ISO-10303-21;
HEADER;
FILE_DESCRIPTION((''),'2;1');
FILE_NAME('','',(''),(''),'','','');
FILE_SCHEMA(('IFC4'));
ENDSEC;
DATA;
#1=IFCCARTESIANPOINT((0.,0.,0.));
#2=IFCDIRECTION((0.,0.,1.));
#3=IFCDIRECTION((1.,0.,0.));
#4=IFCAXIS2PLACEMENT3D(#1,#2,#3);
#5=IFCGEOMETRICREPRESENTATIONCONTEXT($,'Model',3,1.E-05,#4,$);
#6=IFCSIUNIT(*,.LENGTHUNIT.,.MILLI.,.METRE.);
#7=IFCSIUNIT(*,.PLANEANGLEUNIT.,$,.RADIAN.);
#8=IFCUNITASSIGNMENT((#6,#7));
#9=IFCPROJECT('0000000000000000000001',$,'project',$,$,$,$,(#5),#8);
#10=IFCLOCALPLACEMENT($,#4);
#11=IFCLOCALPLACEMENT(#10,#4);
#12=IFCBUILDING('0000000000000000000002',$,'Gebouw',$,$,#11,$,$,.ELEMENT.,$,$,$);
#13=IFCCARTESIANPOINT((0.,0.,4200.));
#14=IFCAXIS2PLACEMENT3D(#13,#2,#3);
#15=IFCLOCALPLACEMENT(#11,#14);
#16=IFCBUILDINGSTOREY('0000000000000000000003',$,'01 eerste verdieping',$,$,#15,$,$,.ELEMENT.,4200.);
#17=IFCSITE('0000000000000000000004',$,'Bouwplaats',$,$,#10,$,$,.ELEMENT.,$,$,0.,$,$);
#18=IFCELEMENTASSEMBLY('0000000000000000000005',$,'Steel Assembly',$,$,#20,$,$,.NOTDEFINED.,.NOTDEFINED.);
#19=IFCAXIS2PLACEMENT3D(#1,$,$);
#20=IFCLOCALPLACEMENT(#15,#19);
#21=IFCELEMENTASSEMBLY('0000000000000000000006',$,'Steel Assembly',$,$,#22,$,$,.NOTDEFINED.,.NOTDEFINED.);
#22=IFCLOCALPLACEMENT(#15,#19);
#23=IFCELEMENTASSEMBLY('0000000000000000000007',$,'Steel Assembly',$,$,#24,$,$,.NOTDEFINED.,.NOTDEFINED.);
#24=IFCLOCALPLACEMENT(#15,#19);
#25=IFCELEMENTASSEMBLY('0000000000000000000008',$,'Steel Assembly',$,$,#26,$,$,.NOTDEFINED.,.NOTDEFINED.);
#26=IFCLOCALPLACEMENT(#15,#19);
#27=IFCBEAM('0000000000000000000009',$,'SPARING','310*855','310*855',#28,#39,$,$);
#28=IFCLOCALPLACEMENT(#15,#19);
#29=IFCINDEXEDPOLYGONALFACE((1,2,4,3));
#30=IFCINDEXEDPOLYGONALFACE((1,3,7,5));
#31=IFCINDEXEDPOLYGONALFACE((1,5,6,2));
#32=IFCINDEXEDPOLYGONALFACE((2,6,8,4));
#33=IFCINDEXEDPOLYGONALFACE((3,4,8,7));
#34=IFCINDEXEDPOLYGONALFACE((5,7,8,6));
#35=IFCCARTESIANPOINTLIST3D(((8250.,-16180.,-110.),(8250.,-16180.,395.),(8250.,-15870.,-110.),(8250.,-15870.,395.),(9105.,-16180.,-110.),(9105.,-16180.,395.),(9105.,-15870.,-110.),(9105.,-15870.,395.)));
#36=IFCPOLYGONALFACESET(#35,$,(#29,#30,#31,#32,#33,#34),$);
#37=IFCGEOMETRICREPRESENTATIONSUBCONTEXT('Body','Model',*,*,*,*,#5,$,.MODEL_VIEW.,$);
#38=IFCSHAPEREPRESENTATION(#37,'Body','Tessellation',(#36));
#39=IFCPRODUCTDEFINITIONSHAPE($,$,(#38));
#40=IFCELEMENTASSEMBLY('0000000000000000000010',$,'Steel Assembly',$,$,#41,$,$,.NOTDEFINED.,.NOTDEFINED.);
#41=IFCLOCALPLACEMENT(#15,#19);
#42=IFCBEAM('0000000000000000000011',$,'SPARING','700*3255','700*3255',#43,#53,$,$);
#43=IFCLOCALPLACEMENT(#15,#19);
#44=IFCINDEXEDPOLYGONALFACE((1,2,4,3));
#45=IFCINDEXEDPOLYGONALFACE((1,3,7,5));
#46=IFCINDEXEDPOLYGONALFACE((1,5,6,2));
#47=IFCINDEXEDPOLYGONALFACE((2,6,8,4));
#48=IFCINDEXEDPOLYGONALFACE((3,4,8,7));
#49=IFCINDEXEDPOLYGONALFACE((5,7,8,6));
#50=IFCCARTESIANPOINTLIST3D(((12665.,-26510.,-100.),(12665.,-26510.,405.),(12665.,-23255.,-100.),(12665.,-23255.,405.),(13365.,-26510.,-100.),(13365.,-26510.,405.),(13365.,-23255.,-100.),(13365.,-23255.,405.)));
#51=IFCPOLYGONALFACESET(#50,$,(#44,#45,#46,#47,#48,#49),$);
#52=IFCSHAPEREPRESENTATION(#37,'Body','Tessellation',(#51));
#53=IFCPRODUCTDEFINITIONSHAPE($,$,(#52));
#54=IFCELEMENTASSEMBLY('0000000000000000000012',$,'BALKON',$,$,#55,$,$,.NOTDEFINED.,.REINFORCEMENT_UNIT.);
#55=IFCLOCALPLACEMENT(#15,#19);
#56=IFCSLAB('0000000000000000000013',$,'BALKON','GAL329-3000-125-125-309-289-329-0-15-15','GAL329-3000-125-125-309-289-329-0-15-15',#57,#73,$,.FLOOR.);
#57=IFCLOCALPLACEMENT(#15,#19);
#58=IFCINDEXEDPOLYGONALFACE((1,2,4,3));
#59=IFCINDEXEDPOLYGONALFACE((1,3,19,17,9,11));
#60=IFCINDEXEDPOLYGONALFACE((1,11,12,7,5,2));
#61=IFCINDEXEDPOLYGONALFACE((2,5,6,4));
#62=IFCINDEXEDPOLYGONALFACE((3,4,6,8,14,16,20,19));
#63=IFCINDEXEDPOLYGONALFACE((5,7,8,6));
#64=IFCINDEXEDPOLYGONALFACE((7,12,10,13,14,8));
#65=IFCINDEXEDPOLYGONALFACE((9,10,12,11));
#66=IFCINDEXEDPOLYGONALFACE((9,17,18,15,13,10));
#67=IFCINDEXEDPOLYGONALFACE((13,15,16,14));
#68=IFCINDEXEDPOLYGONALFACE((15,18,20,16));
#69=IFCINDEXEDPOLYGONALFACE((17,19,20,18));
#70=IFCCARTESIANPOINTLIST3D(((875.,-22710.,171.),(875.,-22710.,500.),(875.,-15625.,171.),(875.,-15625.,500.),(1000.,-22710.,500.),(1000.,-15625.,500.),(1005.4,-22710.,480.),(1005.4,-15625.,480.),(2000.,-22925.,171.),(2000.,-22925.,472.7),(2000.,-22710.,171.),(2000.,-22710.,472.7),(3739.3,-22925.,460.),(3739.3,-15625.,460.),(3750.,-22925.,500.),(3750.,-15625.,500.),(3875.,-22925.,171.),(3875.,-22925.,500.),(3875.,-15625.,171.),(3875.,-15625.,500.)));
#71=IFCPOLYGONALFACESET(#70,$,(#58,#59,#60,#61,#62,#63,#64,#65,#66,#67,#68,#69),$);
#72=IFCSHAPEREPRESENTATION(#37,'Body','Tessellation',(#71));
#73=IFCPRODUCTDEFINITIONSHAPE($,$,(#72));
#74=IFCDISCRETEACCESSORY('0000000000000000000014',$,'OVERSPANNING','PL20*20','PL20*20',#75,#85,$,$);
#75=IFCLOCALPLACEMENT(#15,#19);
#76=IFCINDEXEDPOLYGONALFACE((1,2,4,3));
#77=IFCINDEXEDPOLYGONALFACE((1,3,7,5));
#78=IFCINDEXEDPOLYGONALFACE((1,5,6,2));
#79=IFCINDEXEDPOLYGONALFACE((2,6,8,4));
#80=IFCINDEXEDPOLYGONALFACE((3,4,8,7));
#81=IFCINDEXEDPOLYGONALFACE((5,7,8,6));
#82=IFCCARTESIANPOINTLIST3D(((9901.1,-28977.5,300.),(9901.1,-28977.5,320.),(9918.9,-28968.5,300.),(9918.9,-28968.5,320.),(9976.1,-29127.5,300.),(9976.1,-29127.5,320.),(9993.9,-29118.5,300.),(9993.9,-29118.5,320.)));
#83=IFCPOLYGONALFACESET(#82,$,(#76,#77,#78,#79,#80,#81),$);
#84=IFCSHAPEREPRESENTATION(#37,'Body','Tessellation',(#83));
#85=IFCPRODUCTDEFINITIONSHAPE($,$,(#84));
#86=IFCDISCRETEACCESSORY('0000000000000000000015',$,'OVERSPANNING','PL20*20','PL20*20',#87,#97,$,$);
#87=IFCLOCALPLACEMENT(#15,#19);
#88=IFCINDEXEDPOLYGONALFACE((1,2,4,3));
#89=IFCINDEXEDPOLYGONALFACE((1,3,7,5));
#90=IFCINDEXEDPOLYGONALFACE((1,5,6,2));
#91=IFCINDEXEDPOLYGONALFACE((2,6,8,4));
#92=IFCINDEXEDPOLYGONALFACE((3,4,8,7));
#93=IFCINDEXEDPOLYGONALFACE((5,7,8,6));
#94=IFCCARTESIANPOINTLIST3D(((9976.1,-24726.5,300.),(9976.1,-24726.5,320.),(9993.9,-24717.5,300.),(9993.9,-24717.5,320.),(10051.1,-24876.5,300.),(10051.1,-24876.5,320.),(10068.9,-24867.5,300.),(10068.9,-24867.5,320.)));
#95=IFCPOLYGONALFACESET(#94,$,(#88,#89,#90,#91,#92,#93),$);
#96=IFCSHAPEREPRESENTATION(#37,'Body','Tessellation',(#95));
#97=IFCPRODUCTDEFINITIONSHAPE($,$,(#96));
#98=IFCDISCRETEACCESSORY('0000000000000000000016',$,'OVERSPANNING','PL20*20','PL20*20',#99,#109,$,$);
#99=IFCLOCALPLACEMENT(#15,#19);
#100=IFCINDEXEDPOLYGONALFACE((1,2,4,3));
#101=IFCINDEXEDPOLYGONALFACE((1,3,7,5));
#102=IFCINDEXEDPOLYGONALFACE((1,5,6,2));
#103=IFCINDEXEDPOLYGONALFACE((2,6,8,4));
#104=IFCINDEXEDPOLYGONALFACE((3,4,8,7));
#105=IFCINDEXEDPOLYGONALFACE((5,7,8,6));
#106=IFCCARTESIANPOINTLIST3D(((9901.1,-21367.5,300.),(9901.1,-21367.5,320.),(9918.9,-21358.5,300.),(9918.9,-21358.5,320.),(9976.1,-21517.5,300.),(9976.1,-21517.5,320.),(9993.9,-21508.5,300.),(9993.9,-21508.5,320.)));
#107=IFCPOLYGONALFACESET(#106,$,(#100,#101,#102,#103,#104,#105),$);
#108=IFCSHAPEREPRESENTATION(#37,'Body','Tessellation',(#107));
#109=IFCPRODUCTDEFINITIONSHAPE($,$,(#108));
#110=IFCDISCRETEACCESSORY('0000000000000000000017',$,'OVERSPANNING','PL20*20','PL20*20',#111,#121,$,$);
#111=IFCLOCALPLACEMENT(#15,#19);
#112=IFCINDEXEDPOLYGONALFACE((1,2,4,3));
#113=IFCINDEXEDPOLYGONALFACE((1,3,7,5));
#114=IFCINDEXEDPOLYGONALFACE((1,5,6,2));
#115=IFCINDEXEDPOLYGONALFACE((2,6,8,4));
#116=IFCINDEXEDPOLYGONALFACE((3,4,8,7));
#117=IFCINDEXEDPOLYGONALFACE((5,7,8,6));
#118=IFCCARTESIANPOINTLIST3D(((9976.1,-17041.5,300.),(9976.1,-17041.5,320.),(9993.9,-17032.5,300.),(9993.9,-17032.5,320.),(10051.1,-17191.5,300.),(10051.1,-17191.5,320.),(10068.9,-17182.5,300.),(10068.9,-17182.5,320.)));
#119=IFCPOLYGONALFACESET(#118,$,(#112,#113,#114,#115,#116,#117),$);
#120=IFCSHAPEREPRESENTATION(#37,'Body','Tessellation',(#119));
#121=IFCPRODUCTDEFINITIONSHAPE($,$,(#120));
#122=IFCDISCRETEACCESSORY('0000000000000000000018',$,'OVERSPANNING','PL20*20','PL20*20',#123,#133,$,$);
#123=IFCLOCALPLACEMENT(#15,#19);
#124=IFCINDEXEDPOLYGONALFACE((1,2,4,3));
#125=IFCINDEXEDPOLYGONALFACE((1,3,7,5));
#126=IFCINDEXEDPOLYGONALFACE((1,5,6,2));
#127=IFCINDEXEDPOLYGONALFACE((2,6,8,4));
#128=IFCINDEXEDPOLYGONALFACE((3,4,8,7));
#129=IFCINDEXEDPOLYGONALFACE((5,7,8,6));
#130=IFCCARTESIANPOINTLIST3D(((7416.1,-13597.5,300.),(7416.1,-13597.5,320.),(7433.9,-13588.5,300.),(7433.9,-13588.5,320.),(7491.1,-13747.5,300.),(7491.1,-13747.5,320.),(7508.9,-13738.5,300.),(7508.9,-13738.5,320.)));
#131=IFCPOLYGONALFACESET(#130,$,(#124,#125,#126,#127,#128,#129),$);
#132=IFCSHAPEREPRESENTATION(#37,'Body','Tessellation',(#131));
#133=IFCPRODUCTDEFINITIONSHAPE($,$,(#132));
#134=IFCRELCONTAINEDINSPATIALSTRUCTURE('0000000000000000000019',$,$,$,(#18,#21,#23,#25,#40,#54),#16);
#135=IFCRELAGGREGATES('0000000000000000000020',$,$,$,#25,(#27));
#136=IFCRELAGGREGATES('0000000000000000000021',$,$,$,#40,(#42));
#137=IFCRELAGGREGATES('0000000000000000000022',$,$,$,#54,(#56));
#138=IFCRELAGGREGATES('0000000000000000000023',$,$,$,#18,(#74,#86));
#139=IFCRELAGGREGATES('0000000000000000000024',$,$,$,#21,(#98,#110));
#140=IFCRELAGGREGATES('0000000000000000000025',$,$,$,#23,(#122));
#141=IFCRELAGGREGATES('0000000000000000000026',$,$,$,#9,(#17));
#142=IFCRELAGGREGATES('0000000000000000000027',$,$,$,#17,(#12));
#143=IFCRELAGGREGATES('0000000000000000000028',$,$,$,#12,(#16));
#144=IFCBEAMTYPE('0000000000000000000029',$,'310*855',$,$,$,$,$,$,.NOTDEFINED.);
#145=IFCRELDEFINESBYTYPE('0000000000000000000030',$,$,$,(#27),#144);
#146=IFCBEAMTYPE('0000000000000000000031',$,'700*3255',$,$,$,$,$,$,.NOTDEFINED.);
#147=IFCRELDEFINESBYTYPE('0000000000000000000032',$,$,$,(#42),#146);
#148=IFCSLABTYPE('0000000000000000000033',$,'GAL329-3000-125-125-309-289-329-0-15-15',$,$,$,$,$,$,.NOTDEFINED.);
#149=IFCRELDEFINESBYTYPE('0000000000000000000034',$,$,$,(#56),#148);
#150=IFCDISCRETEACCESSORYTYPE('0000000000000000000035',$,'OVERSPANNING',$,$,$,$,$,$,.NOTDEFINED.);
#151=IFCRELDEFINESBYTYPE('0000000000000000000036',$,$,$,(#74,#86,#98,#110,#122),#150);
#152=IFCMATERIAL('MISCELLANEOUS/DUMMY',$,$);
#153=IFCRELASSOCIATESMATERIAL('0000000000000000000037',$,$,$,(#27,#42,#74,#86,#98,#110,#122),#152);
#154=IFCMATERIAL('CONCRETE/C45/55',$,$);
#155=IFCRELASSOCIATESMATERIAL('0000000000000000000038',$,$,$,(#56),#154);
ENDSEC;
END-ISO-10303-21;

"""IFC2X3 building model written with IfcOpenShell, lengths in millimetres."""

from ifc_helpers import new_model, si_unit, frame, origin_with_axes, origin_2d_with_axis, place, context, subcontext, project, spatial, polyline, rectangle, outline, extrude, boolean, material, type_object, element, aggregate, save


model = new_model("IFC2X3")

# Units and contexts
model_context = context("Model", 3, precision=1e-05, world=origin_with_axes())
body_context = subcontext(model_context, "Body", "Model", "MODEL_VIEW")
ifc_project = project(units=[si_unit("LENGTHUNIT", "METRE", prefix="MILLI"), si_unit("PLANEANGLEUNIT", "RADIAN")], contexts=[model_context])

# Site, building, storey
site_placement = place(None, origin_with_axes())
site = spatial("IfcSite", under=ifc_project, at=site_placement, Name="Bouwplaats", CompositionType="ELEMENT", RefElevation=0.0)
building_placement = place(site_placement, origin_with_axes())
building = spatial("IfcBuilding", under=site, at=building_placement, Name="Gebouw", CompositionType="ELEMENT")
storey_placement = place(building_placement, frame((0.0, 0.0, 4200.0), z_axis=(0.0, 0.0, 1.0), x_axis=(1.0, 0.0, 0.0)))
storey = spatial("IfcBuildingStorey", under=building, at=storey_placement, Name="01 eerste verdieping", CompositionType="ELEMENT", Elevation=4200.0)

# Element assemblies, beams
ifc_material_1 = material(Name="MISCELLANEOUS/DUMMY")
assembly_1_placement = place(storey_placement, origin_with_axes())
assembly_1 = element("IfcElementAssembly", 1, at=assembly_1_placement, inside=storey, Name="Steel Assembly", AssemblyPlace="NOTDEFINED", PredefinedType="NOTDEFINED")
assembly_2_placement = place(storey_placement, origin_with_axes())
assembly_2 = element("IfcElementAssembly", 2, at=assembly_2_placement, inside=storey, Name="Steel Assembly", AssemblyPlace="NOTDEFINED", PredefinedType="NOTDEFINED")
assembly_3_placement = place(storey_placement, origin_with_axes())
assembly_3 = element("IfcElementAssembly", 3, at=assembly_3_placement, inside=storey, Name="Steel Assembly", AssemblyPlace="NOTDEFINED", PredefinedType="NOTDEFINED")
assembly_4_placement = place(storey_placement, origin_with_axes())
assembly_4 = element("IfcElementAssembly", 4, at=assembly_4_placement, inside=storey, Name="Steel Assembly", AssemblyPlace="NOTDEFINED", PredefinedType="NOTDEFINED")
beam_type_1 = type_object("IfcBeamType", Name="310*855", PredefinedType="NOTDEFINED")
beam_1_placement = place(assembly_4_placement, frame((8677.5, -16025.0, 395.0), z_axis=(1.0, -0.000004, 0.0), x_axis=(0.0, 0.0, -1.0)))
beam_1 = element("IfcBeam", 5, at=beam_1_placement, type_object=beam_type_1, material=ifc_material_1, Name="SPARING", Description="310*855", ObjectType="310*855", context=body_context, shape_type="SweptSolid", body=[
    extrude(rectangle(XDim=310.0, YDim=855.0, at=origin_2d_with_axis()), frame((505.0, 0.0, 0.0), z_axis=(-1.0, 0.0, 0.0), x_axis=(0.0, -1.0, 0.0)), (0.0, 0.0, 1.0), 505.0),
])
aggregate(assembly_4, [beam_1])
assembly_5_placement = place(storey_placement, origin_with_axes())
assembly_5 = element("IfcElementAssembly", 6, at=assembly_5_placement, inside=storey, Name="Steel Assembly", AssemblyPlace="NOTDEFINED", PredefinedType="NOTDEFINED")
beam_type_2 = type_object("IfcBeamType", Name="700*3255", PredefinedType="NOTDEFINED")
beam_2_placement = place(assembly_5_placement, frame((13015.0, -24882.5, 405.0), z_axis=(0.000004, 1.0, 0.0), x_axis=(0.0, 0.0, -1.0)))
beam_2 = element("IfcBeam", 7, at=beam_2_placement, type_object=beam_type_2, material=ifc_material_1, Name="SPARING", Description="700*3255", ObjectType="700*3255", context=body_context, shape_type="SweptSolid", body=[
    extrude(rectangle(XDim=700.0, YDim=3255.0, at=origin_2d_with_axis()), frame((505.0, 0.0, 0.0), z_axis=(-1.0, 0.0, 0.0), x_axis=(0.0, -1.0, 0.0)), (0.0, 0.0, 1.0), 505.0),
])
aggregate(assembly_5, [beam_2])

# Element assembly, slab
assembly_6_placement = place(storey_placement, origin_with_axes())
assembly_6 = element("IfcElementAssembly", 8, at=assembly_6_placement, inside=storey, Name="BALKON", AssemblyPlace="NOTDEFINED", PredefinedType="REINFORCEMENT_UNIT")
ifc_material_2 = material(Name="CONCRETE/C45/55")
slab_type = type_object("IfcSlabType", Name="GAL329-3000-125-125-309-289-329-0-15-15", PredefinedType="NOTDEFINED")
slab_placement = place(assembly_6_placement, frame((2375.0, -22925.0, 335.5), z_axis=(0.0, 0.0, 1.0), x_axis=(0.0, 1.0, 0.0)))
slab = element("IfcSlab", 9, at=slab_placement, type_object=slab_type, material=ifc_material_2, Name="BALKON", Description="GAL329-3000-125-125-309-289-329-0-15-15", ObjectType="GAL329-3000-125-125-309-289-329-0-15-15", PredefinedType="FLOOR", context=body_context, shape_type="CSG", body=[
    boolean("DIFFERENCE", extrude(outline(polyline([(1364.3, 124.5), (1375.0, 164.5), (1500.0, 164.5), (1500.0, -164.5), (-1500.0, -164.5), (-1500.0, 164.5), (-1375.0, 164.5), (-1369.6, 144.5), (1364.3, 124.5)])), frame((7300.0, 0.0, 0.0), z_axis=(-1.0, 0.0, 0.0), x_axis=(0.0, -1.0, 0.0)), (0.0, 0.0, 1.0), 7300.0), extrude(rectangle(XDim=350.0, YDim=215.0, at=origin_2d_with_axis()), frame((107.5, 375.0, -10.5), z_axis=(0.0, 1.0, 0.0), x_axis=(0.0, 0.0, -1.0)), (0.0, 0.0, 1.0), 1125.0)),
])
aggregate(assembly_6, [slab])

# Discrete accessories
discrete_accessory_type = type_object("IfcDiscreteAccessoryType", Name="OVERSPANNING")
discrete_accessory_1_placement = place(assembly_1_placement, frame((9910.0, -28973.0, 310.0), z_axis=(0.894427, 0.447214, 0.0), x_axis=(0.447214, -0.894427, 0.0)))
discrete_accessory_1 = element("IfcDiscreteAccessory", 10, at=discrete_accessory_1_placement, type_object=discrete_accessory_type, material=ifc_material_1, Name="OVERSPANNING", Description="PL20*20", ObjectType="PL20*20", context=body_context, shape_type="SweptSolid", body=[
    extrude(rectangle(XDim=20.0, YDim=20.0, at=origin_2d_with_axis()), frame((167.7, 0.0, 0.0), z_axis=(-1.0, 0.0, 0.0), x_axis=(0.0, -1.0, 0.0)), (0.0, 0.0, 1.0), 167.7),
])
discrete_accessory_2_placement = place(assembly_1_placement, frame((10060.0, -24872.0, 310.0), z_axis=(-0.894427, -0.447214, 0.0), x_axis=(-0.447214, 0.894427, 0.0)))
discrete_accessory_2 = element("IfcDiscreteAccessory", 11, at=discrete_accessory_2_placement, type_object=discrete_accessory_type, material=ifc_material_1, Name="OVERSPANNING", Description="PL20*20", ObjectType="PL20*20", context=body_context, shape_type="SweptSolid", body=[
    extrude(rectangle(XDim=20.0, YDim=20.0, at=origin_2d_with_axis()), frame((167.7, 0.0, 0.0), z_axis=(-1.0, 0.0, 0.0), x_axis=(0.0, -1.0, 0.0)), (0.0, 0.0, 1.0), 167.7),
])
aggregate(assembly_1, [discrete_accessory_1, discrete_accessory_2])
discrete_accessory_3_placement = place(assembly_2_placement, frame((9910.0, -21363.0, 310.0), z_axis=(0.894427, 0.447214, 0.0), x_axis=(0.447214, -0.894427, 0.0)))
discrete_accessory_3 = element("IfcDiscreteAccessory", 12, at=discrete_accessory_3_placement, type_object=discrete_accessory_type, material=ifc_material_1, Name="OVERSPANNING", Description="PL20*20", ObjectType="PL20*20", context=body_context, shape_type="SweptSolid", body=[
    extrude(rectangle(XDim=20.0, YDim=20.0, at=origin_2d_with_axis()), frame((167.7, 0.0, 0.0), z_axis=(-1.0, 0.0, 0.0), x_axis=(0.0, -1.0, 0.0)), (0.0, 0.0, 1.0), 167.7),
])
discrete_accessory_4_placement = place(assembly_2_placement, frame((10060.0, -17187.0, 310.0), z_axis=(-0.894427, -0.447214, 0.0), x_axis=(-0.447214, 0.894427, 0.0)))
discrete_accessory_4 = element("IfcDiscreteAccessory", 13, at=discrete_accessory_4_placement, type_object=discrete_accessory_type, material=ifc_material_1, Name="OVERSPANNING", Description="PL20*20", ObjectType="PL20*20", context=body_context, shape_type="SweptSolid", body=[
    extrude(rectangle(XDim=20.0, YDim=20.0, at=origin_2d_with_axis()), frame((167.7, 0.0, 0.0), z_axis=(-1.0, 0.0, 0.0), x_axis=(0.0, -1.0, 0.0)), (0.0, 0.0, 1.0), 167.7),
])
aggregate(assembly_2, [discrete_accessory_3, discrete_accessory_4])
discrete_accessory_5_placement = place(assembly_3_placement, frame((7425.0, -13593.0, 310.0), z_axis=(0.894427, 0.447214, 0.0), x_axis=(0.447214, -0.894427, 0.0)))
discrete_accessory_5 = element("IfcDiscreteAccessory", 14, at=discrete_accessory_5_placement, type_object=discrete_accessory_type, material=ifc_material_1, Name="OVERSPANNING", Description="PL20*20", ObjectType="PL20*20", context=body_context, shape_type="SweptSolid", body=[
    extrude(rectangle(XDim=20.0, YDim=20.0, at=origin_2d_with_axis()), frame((167.7, 0.0, 0.0), z_axis=(-1.0, 0.0, 0.0), x_axis=(0.0, -1.0, 0.0)), (0.0, 0.0, 1.0), 167.7),
])
aggregate(assembly_3, [discrete_accessory_5])

save(model, "model.ifc")
